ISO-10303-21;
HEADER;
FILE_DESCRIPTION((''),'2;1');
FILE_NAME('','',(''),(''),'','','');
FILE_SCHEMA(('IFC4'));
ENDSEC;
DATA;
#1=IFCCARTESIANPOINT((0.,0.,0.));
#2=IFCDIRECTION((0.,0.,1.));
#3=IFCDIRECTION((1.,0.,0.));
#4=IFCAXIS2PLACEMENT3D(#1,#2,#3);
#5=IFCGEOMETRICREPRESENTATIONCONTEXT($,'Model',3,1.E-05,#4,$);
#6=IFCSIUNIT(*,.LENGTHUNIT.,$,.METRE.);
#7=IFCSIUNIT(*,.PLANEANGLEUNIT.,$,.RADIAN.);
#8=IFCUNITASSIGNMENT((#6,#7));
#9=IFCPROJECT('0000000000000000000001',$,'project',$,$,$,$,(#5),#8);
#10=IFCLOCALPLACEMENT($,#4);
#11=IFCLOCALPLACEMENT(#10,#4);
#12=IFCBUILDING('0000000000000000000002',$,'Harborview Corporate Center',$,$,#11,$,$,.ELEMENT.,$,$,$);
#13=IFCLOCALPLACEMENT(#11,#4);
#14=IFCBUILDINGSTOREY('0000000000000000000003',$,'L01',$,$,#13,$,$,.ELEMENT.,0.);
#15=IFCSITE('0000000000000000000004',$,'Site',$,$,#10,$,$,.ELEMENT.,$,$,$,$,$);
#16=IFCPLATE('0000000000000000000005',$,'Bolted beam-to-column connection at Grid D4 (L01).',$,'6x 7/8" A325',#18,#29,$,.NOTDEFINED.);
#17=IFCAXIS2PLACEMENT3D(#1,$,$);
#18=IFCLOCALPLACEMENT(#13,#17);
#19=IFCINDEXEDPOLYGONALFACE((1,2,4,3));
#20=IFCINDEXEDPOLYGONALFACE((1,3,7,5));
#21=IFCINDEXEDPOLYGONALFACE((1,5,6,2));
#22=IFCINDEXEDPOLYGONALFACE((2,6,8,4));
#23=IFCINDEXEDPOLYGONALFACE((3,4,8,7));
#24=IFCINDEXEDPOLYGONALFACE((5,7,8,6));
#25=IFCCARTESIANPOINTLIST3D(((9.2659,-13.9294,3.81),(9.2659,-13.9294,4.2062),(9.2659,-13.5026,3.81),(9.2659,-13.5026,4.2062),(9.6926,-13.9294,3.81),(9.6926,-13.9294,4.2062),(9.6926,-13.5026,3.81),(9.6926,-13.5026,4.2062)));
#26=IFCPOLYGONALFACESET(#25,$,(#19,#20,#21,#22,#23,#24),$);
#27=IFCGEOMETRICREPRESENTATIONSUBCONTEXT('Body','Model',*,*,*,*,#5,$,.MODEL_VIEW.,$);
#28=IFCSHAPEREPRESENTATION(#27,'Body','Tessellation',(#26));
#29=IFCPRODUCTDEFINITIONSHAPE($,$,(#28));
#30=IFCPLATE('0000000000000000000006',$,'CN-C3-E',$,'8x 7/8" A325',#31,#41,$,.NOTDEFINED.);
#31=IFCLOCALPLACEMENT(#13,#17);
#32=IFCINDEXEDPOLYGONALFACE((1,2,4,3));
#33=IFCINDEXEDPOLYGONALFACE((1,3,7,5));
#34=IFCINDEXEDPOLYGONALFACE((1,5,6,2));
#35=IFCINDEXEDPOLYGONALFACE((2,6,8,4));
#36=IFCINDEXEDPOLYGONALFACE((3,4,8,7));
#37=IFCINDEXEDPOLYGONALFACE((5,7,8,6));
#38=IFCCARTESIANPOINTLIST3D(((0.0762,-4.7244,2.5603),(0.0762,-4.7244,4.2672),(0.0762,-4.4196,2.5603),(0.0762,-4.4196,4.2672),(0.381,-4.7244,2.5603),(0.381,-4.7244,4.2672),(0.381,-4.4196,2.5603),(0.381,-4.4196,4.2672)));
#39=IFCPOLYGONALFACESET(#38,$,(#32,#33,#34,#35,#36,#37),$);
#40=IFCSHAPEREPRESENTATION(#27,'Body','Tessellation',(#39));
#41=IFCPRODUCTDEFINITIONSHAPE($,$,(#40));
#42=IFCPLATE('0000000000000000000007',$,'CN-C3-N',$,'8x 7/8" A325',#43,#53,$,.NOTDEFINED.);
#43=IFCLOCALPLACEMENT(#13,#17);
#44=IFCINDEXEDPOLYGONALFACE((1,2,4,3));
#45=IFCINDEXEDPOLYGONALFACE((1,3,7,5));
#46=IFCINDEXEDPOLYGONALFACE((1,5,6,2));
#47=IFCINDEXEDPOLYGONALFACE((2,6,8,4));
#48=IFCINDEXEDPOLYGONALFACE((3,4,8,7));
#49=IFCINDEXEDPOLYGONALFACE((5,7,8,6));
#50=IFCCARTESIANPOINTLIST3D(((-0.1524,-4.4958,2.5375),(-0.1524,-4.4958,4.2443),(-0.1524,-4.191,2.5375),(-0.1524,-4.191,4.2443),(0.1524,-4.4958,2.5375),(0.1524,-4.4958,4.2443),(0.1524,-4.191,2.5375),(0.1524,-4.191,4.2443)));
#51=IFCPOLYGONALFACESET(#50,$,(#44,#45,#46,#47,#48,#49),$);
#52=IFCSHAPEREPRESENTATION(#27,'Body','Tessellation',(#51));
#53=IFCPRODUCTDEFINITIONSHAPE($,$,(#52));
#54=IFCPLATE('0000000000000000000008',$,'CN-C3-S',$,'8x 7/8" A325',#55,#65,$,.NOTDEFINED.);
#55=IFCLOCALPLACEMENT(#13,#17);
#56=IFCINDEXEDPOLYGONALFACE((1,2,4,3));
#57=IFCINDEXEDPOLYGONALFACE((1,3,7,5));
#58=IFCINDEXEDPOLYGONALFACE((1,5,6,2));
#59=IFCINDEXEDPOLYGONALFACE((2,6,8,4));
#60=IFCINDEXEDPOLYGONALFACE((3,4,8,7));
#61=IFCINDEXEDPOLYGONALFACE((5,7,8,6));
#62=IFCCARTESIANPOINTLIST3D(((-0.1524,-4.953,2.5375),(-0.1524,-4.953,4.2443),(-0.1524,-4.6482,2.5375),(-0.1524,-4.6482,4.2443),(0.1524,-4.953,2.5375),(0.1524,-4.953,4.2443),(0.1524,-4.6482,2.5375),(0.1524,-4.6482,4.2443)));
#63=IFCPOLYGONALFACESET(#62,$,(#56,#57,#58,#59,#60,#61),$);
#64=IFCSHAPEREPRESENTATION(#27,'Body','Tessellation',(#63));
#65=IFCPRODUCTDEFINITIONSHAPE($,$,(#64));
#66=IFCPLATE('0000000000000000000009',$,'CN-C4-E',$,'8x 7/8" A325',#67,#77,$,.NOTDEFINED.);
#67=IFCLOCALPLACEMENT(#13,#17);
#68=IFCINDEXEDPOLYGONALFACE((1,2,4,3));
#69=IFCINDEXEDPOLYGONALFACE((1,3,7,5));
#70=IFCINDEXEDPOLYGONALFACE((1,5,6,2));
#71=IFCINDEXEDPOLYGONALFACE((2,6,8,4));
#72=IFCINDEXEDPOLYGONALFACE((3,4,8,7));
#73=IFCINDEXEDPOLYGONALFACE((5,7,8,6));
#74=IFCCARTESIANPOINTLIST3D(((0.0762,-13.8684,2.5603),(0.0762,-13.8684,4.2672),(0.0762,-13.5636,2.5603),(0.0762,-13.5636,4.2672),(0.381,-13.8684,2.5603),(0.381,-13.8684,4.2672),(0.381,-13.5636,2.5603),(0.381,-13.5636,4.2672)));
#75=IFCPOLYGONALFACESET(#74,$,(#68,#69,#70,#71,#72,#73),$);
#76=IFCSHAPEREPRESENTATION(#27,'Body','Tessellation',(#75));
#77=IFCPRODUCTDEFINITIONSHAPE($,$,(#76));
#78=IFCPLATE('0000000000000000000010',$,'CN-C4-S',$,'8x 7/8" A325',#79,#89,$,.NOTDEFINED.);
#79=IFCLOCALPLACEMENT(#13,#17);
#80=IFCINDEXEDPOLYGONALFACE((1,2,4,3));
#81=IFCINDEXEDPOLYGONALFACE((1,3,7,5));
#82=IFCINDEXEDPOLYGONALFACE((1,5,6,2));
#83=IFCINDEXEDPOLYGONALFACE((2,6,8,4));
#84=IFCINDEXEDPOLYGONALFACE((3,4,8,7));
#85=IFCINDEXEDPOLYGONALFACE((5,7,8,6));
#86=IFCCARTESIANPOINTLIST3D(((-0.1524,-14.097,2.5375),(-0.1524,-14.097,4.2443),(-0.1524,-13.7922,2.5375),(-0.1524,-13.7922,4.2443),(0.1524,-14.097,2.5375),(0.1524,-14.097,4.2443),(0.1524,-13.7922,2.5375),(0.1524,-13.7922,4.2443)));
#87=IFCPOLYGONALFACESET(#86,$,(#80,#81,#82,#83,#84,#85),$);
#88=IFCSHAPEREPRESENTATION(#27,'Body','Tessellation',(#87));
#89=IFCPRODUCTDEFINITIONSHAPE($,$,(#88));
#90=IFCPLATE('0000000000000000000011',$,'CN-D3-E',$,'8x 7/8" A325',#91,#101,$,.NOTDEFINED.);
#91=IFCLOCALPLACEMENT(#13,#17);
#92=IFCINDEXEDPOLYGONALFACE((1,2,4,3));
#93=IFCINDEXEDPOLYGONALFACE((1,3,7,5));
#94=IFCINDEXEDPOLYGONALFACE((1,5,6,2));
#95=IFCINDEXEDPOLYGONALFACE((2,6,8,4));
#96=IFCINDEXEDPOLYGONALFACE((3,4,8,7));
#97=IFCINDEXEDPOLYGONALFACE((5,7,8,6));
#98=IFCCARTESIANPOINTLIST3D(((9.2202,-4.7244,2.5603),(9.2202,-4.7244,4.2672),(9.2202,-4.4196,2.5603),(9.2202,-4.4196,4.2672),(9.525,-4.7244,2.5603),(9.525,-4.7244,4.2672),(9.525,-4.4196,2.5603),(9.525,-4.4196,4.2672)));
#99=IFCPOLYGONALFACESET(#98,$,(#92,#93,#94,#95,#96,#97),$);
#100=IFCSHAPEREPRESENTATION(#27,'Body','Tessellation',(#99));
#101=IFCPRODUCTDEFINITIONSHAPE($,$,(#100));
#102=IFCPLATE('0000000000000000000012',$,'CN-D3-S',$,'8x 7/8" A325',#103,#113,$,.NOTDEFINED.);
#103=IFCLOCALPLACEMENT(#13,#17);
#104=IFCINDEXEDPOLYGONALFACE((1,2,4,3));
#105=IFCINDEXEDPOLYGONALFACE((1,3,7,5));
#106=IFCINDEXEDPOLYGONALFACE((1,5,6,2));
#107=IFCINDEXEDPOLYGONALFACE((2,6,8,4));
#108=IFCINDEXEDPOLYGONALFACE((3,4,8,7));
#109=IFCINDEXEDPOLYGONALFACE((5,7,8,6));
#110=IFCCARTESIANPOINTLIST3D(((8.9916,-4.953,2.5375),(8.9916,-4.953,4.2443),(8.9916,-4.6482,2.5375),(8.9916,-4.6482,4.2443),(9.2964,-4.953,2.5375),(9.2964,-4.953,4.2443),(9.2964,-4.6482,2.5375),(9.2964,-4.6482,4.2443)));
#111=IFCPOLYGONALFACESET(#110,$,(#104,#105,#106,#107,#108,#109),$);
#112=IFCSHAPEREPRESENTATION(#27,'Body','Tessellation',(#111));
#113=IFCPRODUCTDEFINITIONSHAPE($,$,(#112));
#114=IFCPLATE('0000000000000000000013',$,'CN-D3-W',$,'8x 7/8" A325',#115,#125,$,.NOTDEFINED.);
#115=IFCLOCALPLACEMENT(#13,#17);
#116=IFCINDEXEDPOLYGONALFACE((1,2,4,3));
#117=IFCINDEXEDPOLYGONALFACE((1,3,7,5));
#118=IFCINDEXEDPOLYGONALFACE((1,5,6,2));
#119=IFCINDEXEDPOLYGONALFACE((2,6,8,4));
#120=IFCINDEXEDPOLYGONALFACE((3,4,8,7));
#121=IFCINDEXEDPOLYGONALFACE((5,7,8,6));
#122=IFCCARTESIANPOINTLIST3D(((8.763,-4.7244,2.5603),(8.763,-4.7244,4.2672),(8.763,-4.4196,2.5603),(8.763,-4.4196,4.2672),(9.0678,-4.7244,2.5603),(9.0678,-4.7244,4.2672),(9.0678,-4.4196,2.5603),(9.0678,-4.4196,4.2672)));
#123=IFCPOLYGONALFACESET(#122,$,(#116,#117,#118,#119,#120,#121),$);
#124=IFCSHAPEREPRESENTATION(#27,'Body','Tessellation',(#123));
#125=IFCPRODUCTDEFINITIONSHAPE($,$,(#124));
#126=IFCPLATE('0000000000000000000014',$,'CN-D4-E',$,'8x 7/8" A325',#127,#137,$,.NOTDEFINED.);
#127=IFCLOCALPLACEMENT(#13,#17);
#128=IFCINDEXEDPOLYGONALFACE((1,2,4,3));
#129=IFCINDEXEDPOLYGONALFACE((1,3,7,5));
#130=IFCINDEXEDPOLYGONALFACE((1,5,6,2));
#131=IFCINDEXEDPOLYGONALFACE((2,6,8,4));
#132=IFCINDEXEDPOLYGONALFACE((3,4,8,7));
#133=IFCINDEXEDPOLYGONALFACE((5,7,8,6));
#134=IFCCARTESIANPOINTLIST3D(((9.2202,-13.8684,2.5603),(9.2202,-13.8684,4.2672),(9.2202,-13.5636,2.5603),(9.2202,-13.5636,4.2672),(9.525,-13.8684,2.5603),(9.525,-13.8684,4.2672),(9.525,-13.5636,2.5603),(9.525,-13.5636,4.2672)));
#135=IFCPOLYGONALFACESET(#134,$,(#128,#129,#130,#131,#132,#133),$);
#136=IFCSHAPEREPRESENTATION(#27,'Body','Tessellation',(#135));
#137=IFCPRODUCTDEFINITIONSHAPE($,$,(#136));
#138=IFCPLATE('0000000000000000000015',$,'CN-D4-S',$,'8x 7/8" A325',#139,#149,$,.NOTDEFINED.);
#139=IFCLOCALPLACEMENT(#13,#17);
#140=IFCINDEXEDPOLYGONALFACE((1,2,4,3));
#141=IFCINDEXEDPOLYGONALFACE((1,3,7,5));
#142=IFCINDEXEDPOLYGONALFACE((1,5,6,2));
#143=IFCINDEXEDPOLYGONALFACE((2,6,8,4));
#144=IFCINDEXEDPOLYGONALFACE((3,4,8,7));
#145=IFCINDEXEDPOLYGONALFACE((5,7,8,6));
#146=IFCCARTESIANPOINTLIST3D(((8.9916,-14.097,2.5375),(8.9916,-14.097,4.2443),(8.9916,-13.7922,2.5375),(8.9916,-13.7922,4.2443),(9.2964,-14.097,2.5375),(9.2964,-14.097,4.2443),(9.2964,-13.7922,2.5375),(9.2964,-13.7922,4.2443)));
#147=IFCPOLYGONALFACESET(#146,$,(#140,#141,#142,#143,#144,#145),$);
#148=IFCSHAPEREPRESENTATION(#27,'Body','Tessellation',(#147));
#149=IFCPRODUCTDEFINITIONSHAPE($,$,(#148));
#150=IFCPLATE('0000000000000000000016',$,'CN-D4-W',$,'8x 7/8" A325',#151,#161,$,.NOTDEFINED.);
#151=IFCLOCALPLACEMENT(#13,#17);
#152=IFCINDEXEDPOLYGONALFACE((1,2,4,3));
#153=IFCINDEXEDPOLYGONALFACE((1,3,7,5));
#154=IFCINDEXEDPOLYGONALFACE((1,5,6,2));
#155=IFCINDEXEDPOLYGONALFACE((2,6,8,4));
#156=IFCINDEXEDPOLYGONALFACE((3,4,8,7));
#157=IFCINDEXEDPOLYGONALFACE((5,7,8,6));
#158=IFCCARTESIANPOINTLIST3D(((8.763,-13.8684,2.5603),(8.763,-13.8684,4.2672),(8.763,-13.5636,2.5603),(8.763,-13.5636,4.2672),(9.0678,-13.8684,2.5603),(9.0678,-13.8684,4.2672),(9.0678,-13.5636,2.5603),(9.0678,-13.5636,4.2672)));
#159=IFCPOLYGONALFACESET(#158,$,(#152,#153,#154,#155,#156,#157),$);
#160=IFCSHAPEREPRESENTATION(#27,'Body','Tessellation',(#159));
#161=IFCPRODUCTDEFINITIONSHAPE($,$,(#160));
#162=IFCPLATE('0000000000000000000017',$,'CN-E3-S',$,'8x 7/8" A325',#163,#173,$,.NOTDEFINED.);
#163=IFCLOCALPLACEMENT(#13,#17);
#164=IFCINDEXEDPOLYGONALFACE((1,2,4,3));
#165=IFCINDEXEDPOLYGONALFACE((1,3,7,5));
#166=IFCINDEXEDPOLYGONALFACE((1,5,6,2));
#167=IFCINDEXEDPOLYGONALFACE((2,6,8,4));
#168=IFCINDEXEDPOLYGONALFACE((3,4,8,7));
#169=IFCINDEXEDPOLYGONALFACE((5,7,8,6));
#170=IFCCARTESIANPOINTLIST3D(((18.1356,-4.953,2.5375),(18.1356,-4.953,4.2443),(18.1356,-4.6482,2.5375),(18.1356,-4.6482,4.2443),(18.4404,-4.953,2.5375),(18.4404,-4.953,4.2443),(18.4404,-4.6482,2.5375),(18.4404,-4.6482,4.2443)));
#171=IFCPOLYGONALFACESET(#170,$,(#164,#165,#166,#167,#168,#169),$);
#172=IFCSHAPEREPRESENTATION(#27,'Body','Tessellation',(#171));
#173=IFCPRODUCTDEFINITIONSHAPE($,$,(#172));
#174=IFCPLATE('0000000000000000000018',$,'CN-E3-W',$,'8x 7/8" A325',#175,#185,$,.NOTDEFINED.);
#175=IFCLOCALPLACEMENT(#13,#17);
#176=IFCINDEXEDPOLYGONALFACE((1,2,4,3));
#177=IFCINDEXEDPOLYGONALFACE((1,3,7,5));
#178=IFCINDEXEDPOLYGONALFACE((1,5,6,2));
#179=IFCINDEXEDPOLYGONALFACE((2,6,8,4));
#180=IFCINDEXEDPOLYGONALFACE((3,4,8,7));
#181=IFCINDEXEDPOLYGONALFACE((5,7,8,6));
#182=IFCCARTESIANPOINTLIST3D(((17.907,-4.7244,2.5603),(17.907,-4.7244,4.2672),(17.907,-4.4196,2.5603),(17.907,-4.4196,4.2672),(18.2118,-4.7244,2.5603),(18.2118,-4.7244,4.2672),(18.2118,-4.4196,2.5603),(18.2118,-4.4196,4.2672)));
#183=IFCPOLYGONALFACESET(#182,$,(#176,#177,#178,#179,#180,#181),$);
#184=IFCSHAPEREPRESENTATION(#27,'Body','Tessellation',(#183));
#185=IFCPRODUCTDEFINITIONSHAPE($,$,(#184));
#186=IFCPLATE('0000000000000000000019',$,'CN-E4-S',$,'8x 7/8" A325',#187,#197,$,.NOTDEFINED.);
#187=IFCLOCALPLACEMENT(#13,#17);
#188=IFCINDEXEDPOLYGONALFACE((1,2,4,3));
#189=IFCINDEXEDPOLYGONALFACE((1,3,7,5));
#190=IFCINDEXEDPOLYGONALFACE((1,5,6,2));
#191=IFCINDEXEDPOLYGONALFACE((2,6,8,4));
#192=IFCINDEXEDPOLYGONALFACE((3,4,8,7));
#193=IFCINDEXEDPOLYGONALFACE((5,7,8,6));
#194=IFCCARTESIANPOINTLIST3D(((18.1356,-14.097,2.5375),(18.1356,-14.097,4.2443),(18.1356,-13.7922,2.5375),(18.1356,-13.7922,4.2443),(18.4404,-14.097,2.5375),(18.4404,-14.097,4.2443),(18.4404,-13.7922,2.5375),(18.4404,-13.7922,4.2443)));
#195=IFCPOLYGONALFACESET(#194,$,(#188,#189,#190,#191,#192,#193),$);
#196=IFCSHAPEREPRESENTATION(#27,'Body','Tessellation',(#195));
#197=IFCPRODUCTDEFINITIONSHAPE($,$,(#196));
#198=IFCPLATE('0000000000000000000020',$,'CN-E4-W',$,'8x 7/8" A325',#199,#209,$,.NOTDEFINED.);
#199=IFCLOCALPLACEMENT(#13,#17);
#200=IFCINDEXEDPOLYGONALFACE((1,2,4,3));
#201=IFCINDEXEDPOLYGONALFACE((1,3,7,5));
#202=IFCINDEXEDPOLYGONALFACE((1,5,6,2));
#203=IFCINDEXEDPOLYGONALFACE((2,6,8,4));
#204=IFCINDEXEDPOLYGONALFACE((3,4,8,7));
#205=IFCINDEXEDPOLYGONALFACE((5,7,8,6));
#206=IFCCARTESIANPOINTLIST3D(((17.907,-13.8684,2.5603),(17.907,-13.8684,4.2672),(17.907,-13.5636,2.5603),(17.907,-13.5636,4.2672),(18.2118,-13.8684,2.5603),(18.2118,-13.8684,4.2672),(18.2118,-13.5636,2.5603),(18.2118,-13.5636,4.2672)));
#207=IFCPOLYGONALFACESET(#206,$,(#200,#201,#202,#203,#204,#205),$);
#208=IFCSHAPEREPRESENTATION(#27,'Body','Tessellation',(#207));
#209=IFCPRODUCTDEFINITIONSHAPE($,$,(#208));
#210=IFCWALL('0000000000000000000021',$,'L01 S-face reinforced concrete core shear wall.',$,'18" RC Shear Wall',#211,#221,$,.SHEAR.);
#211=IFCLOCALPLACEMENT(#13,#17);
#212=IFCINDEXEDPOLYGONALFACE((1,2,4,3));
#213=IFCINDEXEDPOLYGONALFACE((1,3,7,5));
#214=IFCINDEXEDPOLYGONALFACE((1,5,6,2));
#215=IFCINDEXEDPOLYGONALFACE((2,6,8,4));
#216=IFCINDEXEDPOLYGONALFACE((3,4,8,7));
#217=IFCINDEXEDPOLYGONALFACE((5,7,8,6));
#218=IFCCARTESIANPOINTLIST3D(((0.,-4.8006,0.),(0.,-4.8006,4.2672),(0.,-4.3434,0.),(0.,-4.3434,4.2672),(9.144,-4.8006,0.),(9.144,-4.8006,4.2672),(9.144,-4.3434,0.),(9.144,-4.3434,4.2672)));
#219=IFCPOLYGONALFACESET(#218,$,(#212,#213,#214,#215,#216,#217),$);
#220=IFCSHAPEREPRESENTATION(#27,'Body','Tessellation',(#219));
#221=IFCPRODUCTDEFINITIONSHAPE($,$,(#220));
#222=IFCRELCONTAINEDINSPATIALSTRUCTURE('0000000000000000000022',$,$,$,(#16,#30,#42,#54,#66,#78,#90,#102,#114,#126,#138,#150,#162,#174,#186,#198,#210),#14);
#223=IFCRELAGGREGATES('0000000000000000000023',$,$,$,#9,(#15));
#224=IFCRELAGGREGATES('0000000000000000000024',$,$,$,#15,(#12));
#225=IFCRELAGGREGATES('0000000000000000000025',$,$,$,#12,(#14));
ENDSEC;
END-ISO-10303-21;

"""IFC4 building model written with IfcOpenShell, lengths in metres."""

from ifc_helpers import new_model, si_unit, frame, origin_with_axes, place, context, subcontext, project, spatial, rectangle, extrude, element, save


model = new_model("IFC4")

# Units and contexts
model_context = context("Model", 3, precision=1e-05, world=origin_with_axes())
body_context = subcontext(model_context, "Body", "Model", "MODEL_VIEW")
ifc_project = project(units=[si_unit("LENGTHUNIT", "METRE"), si_unit("PLANEANGLEUNIT", "RADIAN")], contexts=[model_context])

# Site, building, storey
site_placement = place(None, origin_with_axes())
site = spatial("IfcSite", under=ifc_project, at=site_placement, Name="Site", CompositionType="ELEMENT")
building_placement = place(site_placement, origin_with_axes())
building = spatial("IfcBuilding", under=site, at=building_placement, Name="Harborview Corporate Center", CompositionType="ELEMENT")
storey_placement = place(building_placement, origin_with_axes())
storey = spatial("IfcBuildingStorey", under=building, at=storey_placement, Name="L01", CompositionType="ELEMENT", Elevation=0.0)

# Plates
plate_1_placement = place(storey_placement, frame((9.4793, -13.716, 3.81), z_axis=(0.0, 0.0, 1.0), x_axis=(1.0, 0.0, 0.0)))
element("IfcPlate", 1, at=plate_1_placement, inside=storey, Name="Bolted beam-to-column connection at Grid D4 (L01).", ObjectType="6x 7/8\" A325", PredefinedType="NOTDEFINED", context=body_context, shape_type="SweptSolid", body=[
    extrude(rectangle(XDim=0.4267, YDim=0.4267), origin_with_axes(), (0.0, 0.0, 1.0), 0.3962),
])
for number, where, z_axis, x_axis, name in (
    (2, (0.2286, -4.572, 2.5603), (0.0, 0.0, 1.0), (1.0, 0.0, 0.0), "CN-C3-E"),
    (3, (0.0, -4.3434, 2.5375), (0.0, 0.0, 1.0), (1.0, 0.0, 0.0), "CN-C3-N"),
    (4, (0.0, -4.8006, 2.5375), (0.0, 0.0, 1.0), (1.0, 0.0, 0.0), "CN-C3-S"),
    (5, (0.2286, -13.716, 2.5603), (0.0, 0.0, 1.0), (1.0, 0.0, 0.0), "CN-C4-E"),
    (6, (0.0, -13.9446, 2.5375), (0.0, 0.0, 1.0), (1.0, 0.0, 0.0), "CN-C4-S"),
):
    element("IfcPlate", number, at=place(storey_placement, frame(where, z_axis=z_axis, x_axis=x_axis)), inside=storey, Name=name, ObjectType="8x 7/8\" A325", PredefinedType="NOTDEFINED", context=body_context, shape_type="SweptSolid", body=[
        extrude(rectangle(XDim=0.3048, YDim=0.3048), origin_with_axes(), (0.0, 0.0, 1.0), 1.7069),
    ])
for number, where, z_axis, x_axis, name in (
    (7, (9.3726, -4.572, 2.5603), (0.0, 0.0, 1.0), (1.0, 0.0, 0.0), "CN-D3-E"),
    (8, (9.144, -4.8006, 2.5375), (0.0, 0.0, 1.0), (1.0, 0.0, 0.0), "CN-D3-S"),
    (9, (8.9154, -4.572, 2.5603), (0.0, 0.0, 1.0), (1.0, 0.0, 0.0), "CN-D3-W"),
    (10, (9.3726, -13.716, 2.5603), (0.0, 0.0, 1.0), (1.0, 0.0, 0.0), "CN-D4-E"),
    (11, (9.144, -13.9446, 2.5375), (0.0, 0.0, 1.0), (1.0, 0.0, 0.0), "CN-D4-S"),
    (12, (8.9154, -13.716, 2.5603), (0.0, 0.0, 1.0), (1.0, 0.0, 0.0), "CN-D4-W"),
    (13, (18.288, -4.8006, 2.5375), (0.0, 0.0, 1.0), (1.0, 0.0, 0.0), "CN-E3-S"),
    (14, (18.0594, -4.572, 2.5603), (0.0, 0.0, 1.0), (1.0, 0.0, 0.0), "CN-E3-W"),
    (15, (18.288, -13.9446, 2.5375), (0.0, 0.0, 1.0), (1.0, 0.0, 0.0), "CN-E4-S"),
    (16, (18.0594, -13.716, 2.5603), (0.0, 0.0, 1.0), (1.0, 0.0, 0.0), "CN-E4-W"),
):
    element("IfcPlate", number, at=place(storey_placement, frame(where, z_axis=z_axis, x_axis=x_axis)), inside=storey, Name=name, ObjectType="8x 7/8\" A325", PredefinedType="NOTDEFINED", context=body_context, shape_type="SweptSolid", body=[
        extrude(rectangle(XDim=0.3048, YDim=0.3048), origin_with_axes(), (0.0, 0.0, 1.0), 1.7069),
    ])

# Wall
wall_placement = place(storey_placement, frame((4.572, -4.572, 0.0), z_axis=(0.0, 0.0, 1.0), x_axis=(1.0, 0.0, 0.0)))
element("IfcWall", 17, at=wall_placement, inside=storey, Name="L01 S-face reinforced concrete core shear wall.", ObjectType="18\" RC Shear Wall", PredefinedType="SHEAR", context=body_context, shape_type="SweptSolid", body=[
    extrude(rectangle(XDim=9.144, YDim=0.4572), origin_with_axes(), (0.0, 0.0, 1.0), 4.2672),
])

save(model, "model.ifc")
